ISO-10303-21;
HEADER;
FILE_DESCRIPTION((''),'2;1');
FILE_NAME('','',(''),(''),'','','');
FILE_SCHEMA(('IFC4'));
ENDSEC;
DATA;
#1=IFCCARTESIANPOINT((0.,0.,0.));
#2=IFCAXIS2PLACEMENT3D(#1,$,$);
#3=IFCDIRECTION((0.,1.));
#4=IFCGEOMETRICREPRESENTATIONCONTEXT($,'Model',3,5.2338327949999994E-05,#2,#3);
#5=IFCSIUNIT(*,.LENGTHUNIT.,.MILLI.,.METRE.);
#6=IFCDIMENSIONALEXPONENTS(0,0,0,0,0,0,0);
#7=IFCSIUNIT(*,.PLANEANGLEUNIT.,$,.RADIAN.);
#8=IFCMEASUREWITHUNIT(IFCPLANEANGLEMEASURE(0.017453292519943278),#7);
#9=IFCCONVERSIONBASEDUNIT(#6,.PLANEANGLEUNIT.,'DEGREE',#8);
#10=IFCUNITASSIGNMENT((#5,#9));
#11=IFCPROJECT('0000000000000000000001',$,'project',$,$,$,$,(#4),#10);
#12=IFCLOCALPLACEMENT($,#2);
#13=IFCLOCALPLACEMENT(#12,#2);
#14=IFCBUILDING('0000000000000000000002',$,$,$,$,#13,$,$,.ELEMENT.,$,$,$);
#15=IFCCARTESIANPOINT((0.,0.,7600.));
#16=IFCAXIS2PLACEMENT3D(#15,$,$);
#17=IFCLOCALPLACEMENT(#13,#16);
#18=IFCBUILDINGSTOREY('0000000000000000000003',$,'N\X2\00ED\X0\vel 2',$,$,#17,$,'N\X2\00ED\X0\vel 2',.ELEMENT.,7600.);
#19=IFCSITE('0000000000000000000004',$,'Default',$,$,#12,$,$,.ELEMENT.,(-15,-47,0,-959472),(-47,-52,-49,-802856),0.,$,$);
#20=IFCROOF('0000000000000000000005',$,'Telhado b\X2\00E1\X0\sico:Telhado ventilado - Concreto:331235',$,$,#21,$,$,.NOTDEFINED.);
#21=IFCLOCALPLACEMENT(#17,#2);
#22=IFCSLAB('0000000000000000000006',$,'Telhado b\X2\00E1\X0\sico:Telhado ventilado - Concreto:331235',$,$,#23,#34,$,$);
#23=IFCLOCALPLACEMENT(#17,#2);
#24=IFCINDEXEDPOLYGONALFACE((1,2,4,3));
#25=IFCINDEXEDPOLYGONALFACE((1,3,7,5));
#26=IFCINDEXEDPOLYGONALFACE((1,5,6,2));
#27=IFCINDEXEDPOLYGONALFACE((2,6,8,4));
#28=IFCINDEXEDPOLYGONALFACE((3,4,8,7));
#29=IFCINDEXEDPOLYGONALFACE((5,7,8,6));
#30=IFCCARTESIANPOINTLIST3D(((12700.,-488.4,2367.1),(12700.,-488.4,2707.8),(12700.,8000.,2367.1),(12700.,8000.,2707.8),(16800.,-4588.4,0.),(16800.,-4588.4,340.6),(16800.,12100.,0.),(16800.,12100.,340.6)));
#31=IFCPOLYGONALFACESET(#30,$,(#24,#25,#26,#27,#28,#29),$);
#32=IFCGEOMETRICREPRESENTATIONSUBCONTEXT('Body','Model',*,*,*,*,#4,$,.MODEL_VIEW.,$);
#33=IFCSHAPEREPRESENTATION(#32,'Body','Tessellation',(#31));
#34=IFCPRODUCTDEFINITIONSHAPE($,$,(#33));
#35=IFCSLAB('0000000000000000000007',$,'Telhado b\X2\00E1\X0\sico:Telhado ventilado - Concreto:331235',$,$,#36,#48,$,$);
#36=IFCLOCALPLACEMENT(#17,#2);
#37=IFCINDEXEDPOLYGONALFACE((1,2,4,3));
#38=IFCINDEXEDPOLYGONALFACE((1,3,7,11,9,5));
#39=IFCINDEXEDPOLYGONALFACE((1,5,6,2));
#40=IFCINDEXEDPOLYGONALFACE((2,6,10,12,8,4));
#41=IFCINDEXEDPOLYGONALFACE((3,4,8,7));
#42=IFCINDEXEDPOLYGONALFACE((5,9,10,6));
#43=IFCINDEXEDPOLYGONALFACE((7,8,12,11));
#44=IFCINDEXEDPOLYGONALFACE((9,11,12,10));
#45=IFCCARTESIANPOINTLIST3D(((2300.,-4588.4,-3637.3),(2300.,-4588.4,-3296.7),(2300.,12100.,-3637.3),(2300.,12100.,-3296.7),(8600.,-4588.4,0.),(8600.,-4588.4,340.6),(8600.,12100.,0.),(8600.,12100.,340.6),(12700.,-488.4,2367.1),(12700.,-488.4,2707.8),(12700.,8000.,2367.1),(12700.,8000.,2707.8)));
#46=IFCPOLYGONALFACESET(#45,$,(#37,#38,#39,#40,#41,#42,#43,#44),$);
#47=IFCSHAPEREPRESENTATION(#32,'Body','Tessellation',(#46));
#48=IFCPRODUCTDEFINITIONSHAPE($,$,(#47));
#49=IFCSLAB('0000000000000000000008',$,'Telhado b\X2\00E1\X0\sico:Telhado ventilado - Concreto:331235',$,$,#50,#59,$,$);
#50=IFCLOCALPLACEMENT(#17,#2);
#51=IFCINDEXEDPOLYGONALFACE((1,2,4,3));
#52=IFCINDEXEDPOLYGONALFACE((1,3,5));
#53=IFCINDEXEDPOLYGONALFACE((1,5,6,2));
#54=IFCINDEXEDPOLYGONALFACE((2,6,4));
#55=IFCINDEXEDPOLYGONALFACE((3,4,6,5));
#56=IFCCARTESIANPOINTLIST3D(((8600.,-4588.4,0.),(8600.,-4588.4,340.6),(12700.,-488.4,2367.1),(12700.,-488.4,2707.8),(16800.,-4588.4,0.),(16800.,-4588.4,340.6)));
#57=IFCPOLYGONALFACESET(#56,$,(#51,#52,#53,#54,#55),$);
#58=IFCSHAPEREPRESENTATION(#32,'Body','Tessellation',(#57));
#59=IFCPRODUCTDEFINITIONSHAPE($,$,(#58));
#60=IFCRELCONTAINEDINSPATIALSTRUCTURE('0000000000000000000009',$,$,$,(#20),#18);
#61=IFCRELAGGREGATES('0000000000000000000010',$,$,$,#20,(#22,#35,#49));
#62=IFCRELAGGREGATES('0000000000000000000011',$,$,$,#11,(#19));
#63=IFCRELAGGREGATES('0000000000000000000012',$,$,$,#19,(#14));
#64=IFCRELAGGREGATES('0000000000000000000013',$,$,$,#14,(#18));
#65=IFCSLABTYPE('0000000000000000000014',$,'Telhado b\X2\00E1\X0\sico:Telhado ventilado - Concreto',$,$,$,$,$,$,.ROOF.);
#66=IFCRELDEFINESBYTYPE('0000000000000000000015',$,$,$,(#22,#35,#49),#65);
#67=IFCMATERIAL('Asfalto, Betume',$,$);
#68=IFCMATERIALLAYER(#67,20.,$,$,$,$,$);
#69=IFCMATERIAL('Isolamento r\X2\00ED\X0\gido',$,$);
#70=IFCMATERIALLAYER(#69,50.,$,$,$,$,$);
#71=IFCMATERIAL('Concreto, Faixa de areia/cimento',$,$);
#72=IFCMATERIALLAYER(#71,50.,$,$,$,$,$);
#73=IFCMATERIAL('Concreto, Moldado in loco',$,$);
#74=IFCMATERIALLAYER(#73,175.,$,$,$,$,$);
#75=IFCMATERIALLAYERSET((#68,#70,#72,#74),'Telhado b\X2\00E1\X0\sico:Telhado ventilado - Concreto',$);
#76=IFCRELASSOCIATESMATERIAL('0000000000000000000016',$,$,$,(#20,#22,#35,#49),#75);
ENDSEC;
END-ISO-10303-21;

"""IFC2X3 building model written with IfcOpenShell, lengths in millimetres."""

from ifc_helpers import new_model, entity, si_unit, converted_unit, direction, frame, origin, place, context, subcontext, project, spatial, polyline, outline, extrude, material, layer, layer_set, type_object, element, aggregate, save


model = new_model("IFC2X3")

# Units and contexts
model_context = context("Model", 3, precision=5.2338327949999994e-05, world=origin(), true_north=direction((0.0, 1.0)))
body_context = subcontext(model_context, "Body", "Model", "MODEL_VIEW")
ifc_project = project(units=[si_unit("LENGTHUNIT", "METRE", prefix="MILLI"), converted_unit("PLANEANGLEUNIT", "DEGREE", entity("IfcPlaneAngleMeasure", 0.017453292519943278), si_unit("PLANEANGLEUNIT", "RADIAN"), dimensions=[0, 0, 0, 0, 0, 0, 0])], contexts=[model_context])

# Site, building, storey
site_placement = place(None, origin())
site = spatial("IfcSite", under=ifc_project, at=site_placement, Name="Default", CompositionType="ELEMENT", RefLatitude=(-15, -47, 0, -959472), RefLongitude=(-47, -52, -49, -802856), RefElevation=0.0)
building_placement = place(site_placement, origin())
building = spatial("IfcBuilding", under=site, at=building_placement, CompositionType="ELEMENT")
storey_placement = place(building_placement, frame((0.0, 0.0, 7600.0)))
storey = spatial("IfcBuildingStorey", under=building, at=storey_placement, Name="Nível 2", LongName="Nível 2", CompositionType="ELEMENT", Elevation=7600.0)

# Roof, slabs
ifc_material_1 = material(Name="Asfalto, Betume")
ifc_layer_1 = layer(ifc_material_1, 20.0)
ifc_material_2 = material(Name="Isolamento rígido")
ifc_layer_2 = layer(ifc_material_2, 50.0)
ifc_material_3 = material(Name="Concreto, Faixa de areia/cimento")
ifc_layer_3 = layer(ifc_material_3, 50.0)
ifc_material_4 = material(Name="Concreto, Moldado in loco")
ifc_layer_4 = layer(ifc_material_4, 175.0)
ifc_layer_set = layer_set([ifc_layer_1, ifc_layer_2, ifc_layer_3, ifc_layer_4], Name="Telhado básico:Telhado ventilado - Concreto")
roof_placement = place(storey_placement, frame((2300.0, -4588.4, -3637.3)))
roof = element("IfcRoof", 1, at=roof_placement, inside=storey, material=ifc_layer_set, Name="Telhado básico:Telhado ventilado - Concreto:331235", ShapeType="NOTDEFINED")
slab_type = type_object("IfcSlabType", Name="Telhado básico:Telhado ventilado - Concreto", PredefinedType="ROOF")
slab_1_placement = place(roof_placement, origin())
slab_1 = element("IfcSlab", 2, at=slab_1_placement, type_object=slab_type, material=ifc_layer_set, Name="Telhado básico:Telhado ventilado - Concreto:331235", context=body_context, shape_type="SweptSolid", body=[
    extrude(outline(polyline([(-2367.1, 4244.2), (-2367.1, -4244.2), (2367.1, -8344.2), (2367.1, 8344.2), (-2367.1, 4244.2)])), frame((12450.0, 8344.2, 4820.9), z_axis=(0.5, 0.0, 0.866025), x_axis=(0.866025, 0.0, -0.5)), (-0.5, 0.0, 0.866025), 340.6),
])
slab_2_placement = place(roof_placement, origin())
slab_2 = element("IfcSlab", 3, at=slab_2_placement, type_object=slab_type, material=ifc_layer_set, Name="Telhado básico:Telhado ventilado - Concreto:331235", context=body_context, shape_type="SweptSolid", body=[
    extrude(outline(polyline([(-6004.4, 8344.2), (-6004.4, -8344.2), (1270.2, -8344.2), (6004.4, -4244.2), (6004.4, 4244.2), (1270.2, 8344.2), (-6004.4, 8344.2)])), frame((5200.0, 8344.2, 3002.2), z_axis=(-0.5, 0.0, 0.866025), x_axis=(0.866025, 0.0, 0.5)), (0.5, 0.0, 0.866025), 340.6),
])
slab_3_placement = place(roof_placement, origin())
slab_3 = element("IfcSlab", 4, at=slab_3_placement, type_object=slab_type, material=ifc_layer_set, Name="Telhado básico:Telhado ventilado - Concreto:331235", context=body_context, shape_type="SweptSolid", body=[
    extrude(outline(polyline([(-4100.0, -2367.1), (4100.0, -2367.1), (0.0, 2367.1), (-4100.0, -2367.1)])), frame((10400.0, 2050.0, 4820.9), z_axis=(0.0, -0.5, 0.866025), x_axis=(1.0, 0.0, 0.0)), (0.0, 0.5, 0.866025), 340.6),
])
aggregate(roof, [slab_1, slab_2, slab_3])

save(model, "model.ifc")
